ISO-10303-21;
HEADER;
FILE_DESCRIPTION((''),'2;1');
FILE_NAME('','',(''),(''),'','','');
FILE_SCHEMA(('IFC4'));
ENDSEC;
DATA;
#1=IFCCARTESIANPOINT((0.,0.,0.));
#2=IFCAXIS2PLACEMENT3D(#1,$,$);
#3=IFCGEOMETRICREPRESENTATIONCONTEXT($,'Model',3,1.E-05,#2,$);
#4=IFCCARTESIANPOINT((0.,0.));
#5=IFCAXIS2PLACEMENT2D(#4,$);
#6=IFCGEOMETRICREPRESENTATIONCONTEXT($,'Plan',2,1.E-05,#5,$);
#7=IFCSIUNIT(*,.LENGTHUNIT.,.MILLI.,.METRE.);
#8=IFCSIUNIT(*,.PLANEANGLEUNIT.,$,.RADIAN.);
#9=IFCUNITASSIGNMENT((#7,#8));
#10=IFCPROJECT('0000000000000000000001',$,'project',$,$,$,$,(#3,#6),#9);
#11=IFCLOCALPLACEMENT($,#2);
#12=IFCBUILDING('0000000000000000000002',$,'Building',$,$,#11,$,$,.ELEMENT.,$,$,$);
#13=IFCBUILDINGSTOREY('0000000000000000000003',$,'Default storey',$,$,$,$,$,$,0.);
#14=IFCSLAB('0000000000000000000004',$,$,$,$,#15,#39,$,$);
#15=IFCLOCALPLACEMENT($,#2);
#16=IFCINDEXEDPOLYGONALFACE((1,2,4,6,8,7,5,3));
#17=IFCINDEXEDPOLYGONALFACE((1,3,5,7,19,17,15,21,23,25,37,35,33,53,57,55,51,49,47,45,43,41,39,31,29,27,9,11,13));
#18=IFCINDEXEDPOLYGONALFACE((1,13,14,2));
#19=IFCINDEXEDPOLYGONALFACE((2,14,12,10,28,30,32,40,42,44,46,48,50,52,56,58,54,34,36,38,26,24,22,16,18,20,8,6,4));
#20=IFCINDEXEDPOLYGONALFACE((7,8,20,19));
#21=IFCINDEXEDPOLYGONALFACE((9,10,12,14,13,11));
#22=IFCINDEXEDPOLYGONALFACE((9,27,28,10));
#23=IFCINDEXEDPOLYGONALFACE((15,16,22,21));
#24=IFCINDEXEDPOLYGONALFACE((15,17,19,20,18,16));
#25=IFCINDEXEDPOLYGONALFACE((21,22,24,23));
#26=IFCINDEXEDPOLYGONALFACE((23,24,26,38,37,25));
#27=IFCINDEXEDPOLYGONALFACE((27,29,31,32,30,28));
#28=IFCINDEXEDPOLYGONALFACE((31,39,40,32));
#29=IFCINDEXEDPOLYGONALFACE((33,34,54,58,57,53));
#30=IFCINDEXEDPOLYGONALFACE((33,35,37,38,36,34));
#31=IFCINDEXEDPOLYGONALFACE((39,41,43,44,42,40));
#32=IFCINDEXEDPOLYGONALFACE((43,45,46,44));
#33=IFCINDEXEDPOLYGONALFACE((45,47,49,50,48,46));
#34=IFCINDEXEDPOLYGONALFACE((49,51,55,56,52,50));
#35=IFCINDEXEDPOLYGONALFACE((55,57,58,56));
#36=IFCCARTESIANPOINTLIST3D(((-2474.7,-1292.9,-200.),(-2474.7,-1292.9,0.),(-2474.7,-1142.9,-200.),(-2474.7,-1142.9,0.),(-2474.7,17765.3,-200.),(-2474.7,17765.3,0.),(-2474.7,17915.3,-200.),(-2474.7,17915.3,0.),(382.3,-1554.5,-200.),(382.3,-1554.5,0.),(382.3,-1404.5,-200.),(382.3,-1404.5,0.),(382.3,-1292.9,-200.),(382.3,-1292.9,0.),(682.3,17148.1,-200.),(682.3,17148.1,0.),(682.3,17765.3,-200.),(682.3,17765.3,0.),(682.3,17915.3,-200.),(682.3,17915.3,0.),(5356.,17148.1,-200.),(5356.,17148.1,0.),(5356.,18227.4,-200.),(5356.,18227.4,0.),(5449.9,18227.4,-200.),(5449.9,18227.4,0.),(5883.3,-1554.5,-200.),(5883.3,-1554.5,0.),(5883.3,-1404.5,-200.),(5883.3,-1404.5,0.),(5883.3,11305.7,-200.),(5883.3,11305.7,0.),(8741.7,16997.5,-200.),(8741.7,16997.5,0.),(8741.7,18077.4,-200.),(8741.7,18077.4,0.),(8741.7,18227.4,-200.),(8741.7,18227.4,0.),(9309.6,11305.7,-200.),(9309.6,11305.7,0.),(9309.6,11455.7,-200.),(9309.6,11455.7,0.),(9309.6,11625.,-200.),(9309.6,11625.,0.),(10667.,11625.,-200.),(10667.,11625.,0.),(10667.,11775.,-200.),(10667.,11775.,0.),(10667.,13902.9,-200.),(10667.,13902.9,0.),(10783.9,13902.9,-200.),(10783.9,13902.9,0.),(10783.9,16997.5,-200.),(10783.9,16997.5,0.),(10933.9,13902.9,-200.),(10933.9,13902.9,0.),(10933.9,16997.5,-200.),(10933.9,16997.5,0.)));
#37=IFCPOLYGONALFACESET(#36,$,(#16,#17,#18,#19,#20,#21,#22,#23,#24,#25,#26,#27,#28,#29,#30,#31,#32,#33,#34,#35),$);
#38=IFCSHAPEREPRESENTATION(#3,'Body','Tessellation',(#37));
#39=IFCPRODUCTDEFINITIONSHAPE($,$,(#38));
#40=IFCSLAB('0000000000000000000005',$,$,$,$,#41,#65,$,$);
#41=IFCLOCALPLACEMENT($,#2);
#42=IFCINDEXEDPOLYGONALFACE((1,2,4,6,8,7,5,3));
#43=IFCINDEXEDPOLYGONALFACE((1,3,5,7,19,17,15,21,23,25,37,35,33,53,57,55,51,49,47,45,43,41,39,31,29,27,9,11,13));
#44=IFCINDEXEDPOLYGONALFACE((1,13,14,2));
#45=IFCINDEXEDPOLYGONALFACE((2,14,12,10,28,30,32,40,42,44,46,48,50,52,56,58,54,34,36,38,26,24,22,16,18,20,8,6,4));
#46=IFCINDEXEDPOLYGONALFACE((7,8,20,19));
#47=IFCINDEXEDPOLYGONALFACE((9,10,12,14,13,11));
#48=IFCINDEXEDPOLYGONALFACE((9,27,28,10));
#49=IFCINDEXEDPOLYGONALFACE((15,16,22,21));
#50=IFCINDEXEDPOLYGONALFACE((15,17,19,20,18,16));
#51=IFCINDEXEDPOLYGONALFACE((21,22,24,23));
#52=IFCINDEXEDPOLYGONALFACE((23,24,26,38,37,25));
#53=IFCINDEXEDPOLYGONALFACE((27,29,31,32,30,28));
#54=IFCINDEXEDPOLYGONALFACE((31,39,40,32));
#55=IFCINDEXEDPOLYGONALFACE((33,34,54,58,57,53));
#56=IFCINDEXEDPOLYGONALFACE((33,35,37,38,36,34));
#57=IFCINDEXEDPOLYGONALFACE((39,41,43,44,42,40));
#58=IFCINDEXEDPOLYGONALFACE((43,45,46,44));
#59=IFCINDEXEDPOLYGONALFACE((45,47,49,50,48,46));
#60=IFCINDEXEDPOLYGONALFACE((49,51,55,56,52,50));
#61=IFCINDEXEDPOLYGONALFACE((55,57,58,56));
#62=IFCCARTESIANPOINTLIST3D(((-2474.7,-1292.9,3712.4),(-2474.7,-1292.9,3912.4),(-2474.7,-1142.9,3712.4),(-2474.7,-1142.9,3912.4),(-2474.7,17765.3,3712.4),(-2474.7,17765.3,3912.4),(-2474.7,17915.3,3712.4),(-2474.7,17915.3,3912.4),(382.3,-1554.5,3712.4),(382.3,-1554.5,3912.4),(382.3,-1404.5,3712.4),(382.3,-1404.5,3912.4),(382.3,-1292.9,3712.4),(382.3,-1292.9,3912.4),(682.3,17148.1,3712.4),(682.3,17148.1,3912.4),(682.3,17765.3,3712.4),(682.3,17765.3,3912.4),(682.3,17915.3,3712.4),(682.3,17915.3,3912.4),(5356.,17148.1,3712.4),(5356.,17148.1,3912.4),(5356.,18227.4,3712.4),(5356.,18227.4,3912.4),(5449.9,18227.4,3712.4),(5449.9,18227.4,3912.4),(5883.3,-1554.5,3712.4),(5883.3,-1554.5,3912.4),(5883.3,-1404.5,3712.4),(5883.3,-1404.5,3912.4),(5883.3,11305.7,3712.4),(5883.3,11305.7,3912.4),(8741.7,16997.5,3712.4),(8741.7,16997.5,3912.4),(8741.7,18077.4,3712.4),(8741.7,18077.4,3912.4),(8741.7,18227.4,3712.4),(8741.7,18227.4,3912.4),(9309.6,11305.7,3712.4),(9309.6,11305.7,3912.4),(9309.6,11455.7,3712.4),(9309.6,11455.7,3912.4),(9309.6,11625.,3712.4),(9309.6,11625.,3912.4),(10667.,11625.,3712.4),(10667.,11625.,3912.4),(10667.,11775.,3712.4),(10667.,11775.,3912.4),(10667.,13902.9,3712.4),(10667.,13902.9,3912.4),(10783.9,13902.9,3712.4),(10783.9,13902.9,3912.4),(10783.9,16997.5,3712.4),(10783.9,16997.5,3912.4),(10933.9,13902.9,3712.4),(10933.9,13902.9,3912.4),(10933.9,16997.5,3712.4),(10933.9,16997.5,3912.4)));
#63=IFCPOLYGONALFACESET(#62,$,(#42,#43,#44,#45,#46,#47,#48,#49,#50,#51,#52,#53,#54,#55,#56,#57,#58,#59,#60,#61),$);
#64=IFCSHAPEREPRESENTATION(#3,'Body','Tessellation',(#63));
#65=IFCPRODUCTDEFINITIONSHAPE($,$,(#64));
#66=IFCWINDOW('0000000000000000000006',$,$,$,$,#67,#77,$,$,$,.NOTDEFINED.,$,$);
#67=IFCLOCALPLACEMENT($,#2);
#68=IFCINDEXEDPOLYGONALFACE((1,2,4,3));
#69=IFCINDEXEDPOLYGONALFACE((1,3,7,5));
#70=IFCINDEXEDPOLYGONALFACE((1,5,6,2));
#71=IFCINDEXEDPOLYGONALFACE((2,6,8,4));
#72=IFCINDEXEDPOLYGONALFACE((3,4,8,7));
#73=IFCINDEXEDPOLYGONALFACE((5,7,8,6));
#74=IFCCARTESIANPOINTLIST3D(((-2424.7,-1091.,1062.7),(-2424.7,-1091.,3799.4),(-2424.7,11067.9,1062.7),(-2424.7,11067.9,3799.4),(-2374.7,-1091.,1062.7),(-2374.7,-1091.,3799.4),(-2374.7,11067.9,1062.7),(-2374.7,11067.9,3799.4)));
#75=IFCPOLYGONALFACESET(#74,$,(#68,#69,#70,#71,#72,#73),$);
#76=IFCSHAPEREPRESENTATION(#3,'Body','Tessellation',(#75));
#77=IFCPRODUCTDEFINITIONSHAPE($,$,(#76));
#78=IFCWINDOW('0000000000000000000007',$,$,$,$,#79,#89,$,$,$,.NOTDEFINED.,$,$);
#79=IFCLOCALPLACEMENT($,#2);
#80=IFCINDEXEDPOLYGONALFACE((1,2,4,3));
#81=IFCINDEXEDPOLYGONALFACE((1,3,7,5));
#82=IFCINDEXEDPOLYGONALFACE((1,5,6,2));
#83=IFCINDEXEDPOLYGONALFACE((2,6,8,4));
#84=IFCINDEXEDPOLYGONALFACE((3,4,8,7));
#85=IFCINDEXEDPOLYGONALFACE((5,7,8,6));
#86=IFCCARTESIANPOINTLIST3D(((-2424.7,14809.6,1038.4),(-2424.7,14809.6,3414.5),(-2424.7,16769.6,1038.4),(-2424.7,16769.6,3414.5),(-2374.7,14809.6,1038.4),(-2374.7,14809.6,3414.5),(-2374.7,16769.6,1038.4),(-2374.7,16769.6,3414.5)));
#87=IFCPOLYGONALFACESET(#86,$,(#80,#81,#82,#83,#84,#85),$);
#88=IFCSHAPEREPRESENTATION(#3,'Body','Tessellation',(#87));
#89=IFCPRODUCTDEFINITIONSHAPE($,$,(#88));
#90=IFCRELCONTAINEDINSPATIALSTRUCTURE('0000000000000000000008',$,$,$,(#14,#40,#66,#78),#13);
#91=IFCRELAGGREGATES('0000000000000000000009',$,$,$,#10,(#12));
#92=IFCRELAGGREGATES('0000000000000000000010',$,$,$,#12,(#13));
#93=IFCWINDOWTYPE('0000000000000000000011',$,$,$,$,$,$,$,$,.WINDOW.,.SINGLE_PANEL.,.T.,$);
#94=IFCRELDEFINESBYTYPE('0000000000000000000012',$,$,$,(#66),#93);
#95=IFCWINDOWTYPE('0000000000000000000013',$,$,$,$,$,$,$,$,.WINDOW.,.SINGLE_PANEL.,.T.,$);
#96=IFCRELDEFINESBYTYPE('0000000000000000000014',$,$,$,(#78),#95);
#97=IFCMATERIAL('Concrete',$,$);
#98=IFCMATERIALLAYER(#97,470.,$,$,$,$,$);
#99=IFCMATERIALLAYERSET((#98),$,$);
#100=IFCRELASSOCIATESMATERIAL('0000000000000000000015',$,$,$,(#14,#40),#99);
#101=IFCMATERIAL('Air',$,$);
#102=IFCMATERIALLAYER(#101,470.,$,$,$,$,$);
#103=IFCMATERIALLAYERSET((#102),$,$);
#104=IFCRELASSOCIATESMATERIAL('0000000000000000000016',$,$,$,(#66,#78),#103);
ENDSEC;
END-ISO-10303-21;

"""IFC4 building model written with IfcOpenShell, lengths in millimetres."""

from ifc_helpers import new_model, si_unit, frame, origin, origin_2d, place, context, project, spatial, polyline, rectangle, outline, extrude, boolean, material, layer, layer_set, layer_usage, type_object, element, save


model = new_model("IFC4")

# Units and contexts
model_context = context("Model", 3, precision=1e-05, world=origin())
plan_context = context("Plan", 2, precision=1e-05, world=origin_2d())
ifc_project = project(units=[si_unit("LENGTHUNIT", "METRE", prefix="MILLI"), si_unit("PLANEANGLEUNIT", "RADIAN")], contexts=[model_context, plan_context])

# Building, storey
placement = place(None, origin())
building = spatial("IfcBuilding", under=ifc_project, at=placement, Name="Building", CompositionType="ELEMENT")
storey = spatial("IfcBuildingStorey", under=building, Name="Default storey", Elevation=0.0)

# Slabs
ifc_material_1 = material(Name="Concrete")
ifc_layer_1 = layer(ifc_material_1, 470.0)
ifc_layer_set_1 = layer_set([ifc_layer_1])
ifc_layer_usage_1 = layer_usage(ifc_layer_set_1, "AXIS3", "POSITIVE", 0.0)
element("IfcSlab", 1, at=placement, inside=storey, material=ifc_layer_usage_1, context=model_context, shape_type="SweptSolid", body=[
    extrude(outline(polyline([(8741.7, 16997.5), (8741.7, 18077.4), (8741.7, 18227.4), (5449.9, 18227.4), (5356.0, 18227.4), (5356.0, 17148.1), (682.3, 17148.1), (682.3, 17765.3), (682.3, 17915.3), (-2474.7, 17915.3), (-2474.7, 17765.3), (-2474.7, -1142.9), (-2474.7, -1292.9), (382.3, -1292.9), (382.3, -1404.5), (382.3, -1554.5), (5883.3, -1554.5), (5883.3, -1404.5), (5883.3, 11305.7), (9309.6, 11305.7), (9309.6, 11455.7), (9309.6, 11625.0), (10667.0, 11625.0), (10667.0, 11775.0), (10667.0, 13902.9), (10783.9, 13902.9), (10933.9, 13902.9), (10933.9, 16997.5), (10783.9, 16997.5), (8741.7, 16997.5)])), frame((0.0, 0.0, -200.0), z_axis=(0.0, 0.0, 1000.0), x_axis=(1000.0, 0.0, 0.0)), (0.0, 0.0, 1.0), 200.0),
])
element("IfcSlab", 2, at=placement, inside=storey, material=ifc_layer_usage_1, context=model_context, shape_type="SweptSolid", body=[
    extrude(outline(polyline([(8741.7, 16997.5), (8741.7, 18077.4), (8741.7, 18227.4), (5449.9, 18227.4), (5356.0, 18227.4), (5356.0, 17148.1), (682.3, 17148.1), (682.3, 17765.3), (682.3, 17915.3), (-2474.7, 17915.3), (-2474.7, 17765.3), (-2474.7, -1142.9), (-2474.7, -1292.9), (382.3, -1292.9), (382.3, -1404.5), (382.3, -1554.5), (5883.3, -1554.5), (5883.3, -1404.5), (5883.3, 11305.7), (9309.6, 11305.7), (9309.6, 11455.7), (9309.6, 11625.0), (10667.0, 11625.0), (10667.0, 11775.0), (10667.0, 13902.9), (10783.9, 13902.9), (10933.9, 13902.9), (10933.9, 16997.5), (10783.9, 16997.5), (8741.7, 16997.5)])), frame((0.0, 0.0, 3912.4), z_axis=(0.0, 0.0, 1000.0), x_axis=(1000.0, 0.0, 0.0)), (0.0, 0.0, -1.0), 200.0),
])

# Windows
ifc_material_2 = material(Name="Air")
ifc_layer_2 = layer(ifc_material_2, 470.0)
ifc_layer_set_2 = layer_set([ifc_layer_2])
ifc_layer_usage_2 = layer_usage(ifc_layer_set_2, "AXIS3", "POSITIVE", 0.0)
window_type_1 = type_object("IfcWindowType", ParameterTakesPrecedence=True, PartitioningType="SINGLE_PANEL", PredefinedType="WINDOW")
element("IfcWindow", 3, at=placement, inside=storey, type_object=window_type_1, material=ifc_layer_usage_2, PredefinedType="NOTDEFINED", context=model_context, shape_type="CSG", body=[
    boolean("INTERSECTION", extrude(rectangle(XDim=12158.9, YDim=50.0, at=origin_2d()), frame((-2399.7, 4988.4, 1062.7), z_axis=(0.0, 0.0, 1000.0), x_axis=(0.0, 12158.909678, 0.0)), (0.0, 0.0, 1.0), 2736.7), extrude(rectangle(XDim=12158.9, YDim=50.0, at=origin_2d()), frame((-2399.7, 4988.4, 1062.7), z_axis=(0.0, 0.0, 1000.0), x_axis=(0.0, 12158.909678, 0.0)), (0.0, 0.0, 1.0), 2736.7)),
])
window_type_2 = type_object("IfcWindowType", ParameterTakesPrecedence=True, PartitioningType="SINGLE_PANEL", PredefinedType="WINDOW")
element("IfcWindow", 4, at=placement, inside=storey, type_object=window_type_2, material=ifc_layer_usage_2, PredefinedType="NOTDEFINED", context=model_context, shape_type="CSG", body=[
    boolean("INTERSECTION", extrude(rectangle(XDim=1960.0, YDim=50.0, at=origin_2d()), frame((-2399.7, 15789.6, 1038.4), z_axis=(0.0, 0.0, 1000.0), x_axis=(0.0, 1960.000038, 0.0)), (0.0, 0.0, 1.0), 2376.1), extrude(rectangle(XDim=1960.0, YDim=50.0, at=origin_2d()), frame((-2399.7, 15789.6, 1038.4), z_axis=(0.0, 0.0, 1000.0), x_axis=(0.0, 1960.000038, 0.0)), (0.0, 0.0, 1.0), 2376.1)),
])

save(model, "model.ifc")
